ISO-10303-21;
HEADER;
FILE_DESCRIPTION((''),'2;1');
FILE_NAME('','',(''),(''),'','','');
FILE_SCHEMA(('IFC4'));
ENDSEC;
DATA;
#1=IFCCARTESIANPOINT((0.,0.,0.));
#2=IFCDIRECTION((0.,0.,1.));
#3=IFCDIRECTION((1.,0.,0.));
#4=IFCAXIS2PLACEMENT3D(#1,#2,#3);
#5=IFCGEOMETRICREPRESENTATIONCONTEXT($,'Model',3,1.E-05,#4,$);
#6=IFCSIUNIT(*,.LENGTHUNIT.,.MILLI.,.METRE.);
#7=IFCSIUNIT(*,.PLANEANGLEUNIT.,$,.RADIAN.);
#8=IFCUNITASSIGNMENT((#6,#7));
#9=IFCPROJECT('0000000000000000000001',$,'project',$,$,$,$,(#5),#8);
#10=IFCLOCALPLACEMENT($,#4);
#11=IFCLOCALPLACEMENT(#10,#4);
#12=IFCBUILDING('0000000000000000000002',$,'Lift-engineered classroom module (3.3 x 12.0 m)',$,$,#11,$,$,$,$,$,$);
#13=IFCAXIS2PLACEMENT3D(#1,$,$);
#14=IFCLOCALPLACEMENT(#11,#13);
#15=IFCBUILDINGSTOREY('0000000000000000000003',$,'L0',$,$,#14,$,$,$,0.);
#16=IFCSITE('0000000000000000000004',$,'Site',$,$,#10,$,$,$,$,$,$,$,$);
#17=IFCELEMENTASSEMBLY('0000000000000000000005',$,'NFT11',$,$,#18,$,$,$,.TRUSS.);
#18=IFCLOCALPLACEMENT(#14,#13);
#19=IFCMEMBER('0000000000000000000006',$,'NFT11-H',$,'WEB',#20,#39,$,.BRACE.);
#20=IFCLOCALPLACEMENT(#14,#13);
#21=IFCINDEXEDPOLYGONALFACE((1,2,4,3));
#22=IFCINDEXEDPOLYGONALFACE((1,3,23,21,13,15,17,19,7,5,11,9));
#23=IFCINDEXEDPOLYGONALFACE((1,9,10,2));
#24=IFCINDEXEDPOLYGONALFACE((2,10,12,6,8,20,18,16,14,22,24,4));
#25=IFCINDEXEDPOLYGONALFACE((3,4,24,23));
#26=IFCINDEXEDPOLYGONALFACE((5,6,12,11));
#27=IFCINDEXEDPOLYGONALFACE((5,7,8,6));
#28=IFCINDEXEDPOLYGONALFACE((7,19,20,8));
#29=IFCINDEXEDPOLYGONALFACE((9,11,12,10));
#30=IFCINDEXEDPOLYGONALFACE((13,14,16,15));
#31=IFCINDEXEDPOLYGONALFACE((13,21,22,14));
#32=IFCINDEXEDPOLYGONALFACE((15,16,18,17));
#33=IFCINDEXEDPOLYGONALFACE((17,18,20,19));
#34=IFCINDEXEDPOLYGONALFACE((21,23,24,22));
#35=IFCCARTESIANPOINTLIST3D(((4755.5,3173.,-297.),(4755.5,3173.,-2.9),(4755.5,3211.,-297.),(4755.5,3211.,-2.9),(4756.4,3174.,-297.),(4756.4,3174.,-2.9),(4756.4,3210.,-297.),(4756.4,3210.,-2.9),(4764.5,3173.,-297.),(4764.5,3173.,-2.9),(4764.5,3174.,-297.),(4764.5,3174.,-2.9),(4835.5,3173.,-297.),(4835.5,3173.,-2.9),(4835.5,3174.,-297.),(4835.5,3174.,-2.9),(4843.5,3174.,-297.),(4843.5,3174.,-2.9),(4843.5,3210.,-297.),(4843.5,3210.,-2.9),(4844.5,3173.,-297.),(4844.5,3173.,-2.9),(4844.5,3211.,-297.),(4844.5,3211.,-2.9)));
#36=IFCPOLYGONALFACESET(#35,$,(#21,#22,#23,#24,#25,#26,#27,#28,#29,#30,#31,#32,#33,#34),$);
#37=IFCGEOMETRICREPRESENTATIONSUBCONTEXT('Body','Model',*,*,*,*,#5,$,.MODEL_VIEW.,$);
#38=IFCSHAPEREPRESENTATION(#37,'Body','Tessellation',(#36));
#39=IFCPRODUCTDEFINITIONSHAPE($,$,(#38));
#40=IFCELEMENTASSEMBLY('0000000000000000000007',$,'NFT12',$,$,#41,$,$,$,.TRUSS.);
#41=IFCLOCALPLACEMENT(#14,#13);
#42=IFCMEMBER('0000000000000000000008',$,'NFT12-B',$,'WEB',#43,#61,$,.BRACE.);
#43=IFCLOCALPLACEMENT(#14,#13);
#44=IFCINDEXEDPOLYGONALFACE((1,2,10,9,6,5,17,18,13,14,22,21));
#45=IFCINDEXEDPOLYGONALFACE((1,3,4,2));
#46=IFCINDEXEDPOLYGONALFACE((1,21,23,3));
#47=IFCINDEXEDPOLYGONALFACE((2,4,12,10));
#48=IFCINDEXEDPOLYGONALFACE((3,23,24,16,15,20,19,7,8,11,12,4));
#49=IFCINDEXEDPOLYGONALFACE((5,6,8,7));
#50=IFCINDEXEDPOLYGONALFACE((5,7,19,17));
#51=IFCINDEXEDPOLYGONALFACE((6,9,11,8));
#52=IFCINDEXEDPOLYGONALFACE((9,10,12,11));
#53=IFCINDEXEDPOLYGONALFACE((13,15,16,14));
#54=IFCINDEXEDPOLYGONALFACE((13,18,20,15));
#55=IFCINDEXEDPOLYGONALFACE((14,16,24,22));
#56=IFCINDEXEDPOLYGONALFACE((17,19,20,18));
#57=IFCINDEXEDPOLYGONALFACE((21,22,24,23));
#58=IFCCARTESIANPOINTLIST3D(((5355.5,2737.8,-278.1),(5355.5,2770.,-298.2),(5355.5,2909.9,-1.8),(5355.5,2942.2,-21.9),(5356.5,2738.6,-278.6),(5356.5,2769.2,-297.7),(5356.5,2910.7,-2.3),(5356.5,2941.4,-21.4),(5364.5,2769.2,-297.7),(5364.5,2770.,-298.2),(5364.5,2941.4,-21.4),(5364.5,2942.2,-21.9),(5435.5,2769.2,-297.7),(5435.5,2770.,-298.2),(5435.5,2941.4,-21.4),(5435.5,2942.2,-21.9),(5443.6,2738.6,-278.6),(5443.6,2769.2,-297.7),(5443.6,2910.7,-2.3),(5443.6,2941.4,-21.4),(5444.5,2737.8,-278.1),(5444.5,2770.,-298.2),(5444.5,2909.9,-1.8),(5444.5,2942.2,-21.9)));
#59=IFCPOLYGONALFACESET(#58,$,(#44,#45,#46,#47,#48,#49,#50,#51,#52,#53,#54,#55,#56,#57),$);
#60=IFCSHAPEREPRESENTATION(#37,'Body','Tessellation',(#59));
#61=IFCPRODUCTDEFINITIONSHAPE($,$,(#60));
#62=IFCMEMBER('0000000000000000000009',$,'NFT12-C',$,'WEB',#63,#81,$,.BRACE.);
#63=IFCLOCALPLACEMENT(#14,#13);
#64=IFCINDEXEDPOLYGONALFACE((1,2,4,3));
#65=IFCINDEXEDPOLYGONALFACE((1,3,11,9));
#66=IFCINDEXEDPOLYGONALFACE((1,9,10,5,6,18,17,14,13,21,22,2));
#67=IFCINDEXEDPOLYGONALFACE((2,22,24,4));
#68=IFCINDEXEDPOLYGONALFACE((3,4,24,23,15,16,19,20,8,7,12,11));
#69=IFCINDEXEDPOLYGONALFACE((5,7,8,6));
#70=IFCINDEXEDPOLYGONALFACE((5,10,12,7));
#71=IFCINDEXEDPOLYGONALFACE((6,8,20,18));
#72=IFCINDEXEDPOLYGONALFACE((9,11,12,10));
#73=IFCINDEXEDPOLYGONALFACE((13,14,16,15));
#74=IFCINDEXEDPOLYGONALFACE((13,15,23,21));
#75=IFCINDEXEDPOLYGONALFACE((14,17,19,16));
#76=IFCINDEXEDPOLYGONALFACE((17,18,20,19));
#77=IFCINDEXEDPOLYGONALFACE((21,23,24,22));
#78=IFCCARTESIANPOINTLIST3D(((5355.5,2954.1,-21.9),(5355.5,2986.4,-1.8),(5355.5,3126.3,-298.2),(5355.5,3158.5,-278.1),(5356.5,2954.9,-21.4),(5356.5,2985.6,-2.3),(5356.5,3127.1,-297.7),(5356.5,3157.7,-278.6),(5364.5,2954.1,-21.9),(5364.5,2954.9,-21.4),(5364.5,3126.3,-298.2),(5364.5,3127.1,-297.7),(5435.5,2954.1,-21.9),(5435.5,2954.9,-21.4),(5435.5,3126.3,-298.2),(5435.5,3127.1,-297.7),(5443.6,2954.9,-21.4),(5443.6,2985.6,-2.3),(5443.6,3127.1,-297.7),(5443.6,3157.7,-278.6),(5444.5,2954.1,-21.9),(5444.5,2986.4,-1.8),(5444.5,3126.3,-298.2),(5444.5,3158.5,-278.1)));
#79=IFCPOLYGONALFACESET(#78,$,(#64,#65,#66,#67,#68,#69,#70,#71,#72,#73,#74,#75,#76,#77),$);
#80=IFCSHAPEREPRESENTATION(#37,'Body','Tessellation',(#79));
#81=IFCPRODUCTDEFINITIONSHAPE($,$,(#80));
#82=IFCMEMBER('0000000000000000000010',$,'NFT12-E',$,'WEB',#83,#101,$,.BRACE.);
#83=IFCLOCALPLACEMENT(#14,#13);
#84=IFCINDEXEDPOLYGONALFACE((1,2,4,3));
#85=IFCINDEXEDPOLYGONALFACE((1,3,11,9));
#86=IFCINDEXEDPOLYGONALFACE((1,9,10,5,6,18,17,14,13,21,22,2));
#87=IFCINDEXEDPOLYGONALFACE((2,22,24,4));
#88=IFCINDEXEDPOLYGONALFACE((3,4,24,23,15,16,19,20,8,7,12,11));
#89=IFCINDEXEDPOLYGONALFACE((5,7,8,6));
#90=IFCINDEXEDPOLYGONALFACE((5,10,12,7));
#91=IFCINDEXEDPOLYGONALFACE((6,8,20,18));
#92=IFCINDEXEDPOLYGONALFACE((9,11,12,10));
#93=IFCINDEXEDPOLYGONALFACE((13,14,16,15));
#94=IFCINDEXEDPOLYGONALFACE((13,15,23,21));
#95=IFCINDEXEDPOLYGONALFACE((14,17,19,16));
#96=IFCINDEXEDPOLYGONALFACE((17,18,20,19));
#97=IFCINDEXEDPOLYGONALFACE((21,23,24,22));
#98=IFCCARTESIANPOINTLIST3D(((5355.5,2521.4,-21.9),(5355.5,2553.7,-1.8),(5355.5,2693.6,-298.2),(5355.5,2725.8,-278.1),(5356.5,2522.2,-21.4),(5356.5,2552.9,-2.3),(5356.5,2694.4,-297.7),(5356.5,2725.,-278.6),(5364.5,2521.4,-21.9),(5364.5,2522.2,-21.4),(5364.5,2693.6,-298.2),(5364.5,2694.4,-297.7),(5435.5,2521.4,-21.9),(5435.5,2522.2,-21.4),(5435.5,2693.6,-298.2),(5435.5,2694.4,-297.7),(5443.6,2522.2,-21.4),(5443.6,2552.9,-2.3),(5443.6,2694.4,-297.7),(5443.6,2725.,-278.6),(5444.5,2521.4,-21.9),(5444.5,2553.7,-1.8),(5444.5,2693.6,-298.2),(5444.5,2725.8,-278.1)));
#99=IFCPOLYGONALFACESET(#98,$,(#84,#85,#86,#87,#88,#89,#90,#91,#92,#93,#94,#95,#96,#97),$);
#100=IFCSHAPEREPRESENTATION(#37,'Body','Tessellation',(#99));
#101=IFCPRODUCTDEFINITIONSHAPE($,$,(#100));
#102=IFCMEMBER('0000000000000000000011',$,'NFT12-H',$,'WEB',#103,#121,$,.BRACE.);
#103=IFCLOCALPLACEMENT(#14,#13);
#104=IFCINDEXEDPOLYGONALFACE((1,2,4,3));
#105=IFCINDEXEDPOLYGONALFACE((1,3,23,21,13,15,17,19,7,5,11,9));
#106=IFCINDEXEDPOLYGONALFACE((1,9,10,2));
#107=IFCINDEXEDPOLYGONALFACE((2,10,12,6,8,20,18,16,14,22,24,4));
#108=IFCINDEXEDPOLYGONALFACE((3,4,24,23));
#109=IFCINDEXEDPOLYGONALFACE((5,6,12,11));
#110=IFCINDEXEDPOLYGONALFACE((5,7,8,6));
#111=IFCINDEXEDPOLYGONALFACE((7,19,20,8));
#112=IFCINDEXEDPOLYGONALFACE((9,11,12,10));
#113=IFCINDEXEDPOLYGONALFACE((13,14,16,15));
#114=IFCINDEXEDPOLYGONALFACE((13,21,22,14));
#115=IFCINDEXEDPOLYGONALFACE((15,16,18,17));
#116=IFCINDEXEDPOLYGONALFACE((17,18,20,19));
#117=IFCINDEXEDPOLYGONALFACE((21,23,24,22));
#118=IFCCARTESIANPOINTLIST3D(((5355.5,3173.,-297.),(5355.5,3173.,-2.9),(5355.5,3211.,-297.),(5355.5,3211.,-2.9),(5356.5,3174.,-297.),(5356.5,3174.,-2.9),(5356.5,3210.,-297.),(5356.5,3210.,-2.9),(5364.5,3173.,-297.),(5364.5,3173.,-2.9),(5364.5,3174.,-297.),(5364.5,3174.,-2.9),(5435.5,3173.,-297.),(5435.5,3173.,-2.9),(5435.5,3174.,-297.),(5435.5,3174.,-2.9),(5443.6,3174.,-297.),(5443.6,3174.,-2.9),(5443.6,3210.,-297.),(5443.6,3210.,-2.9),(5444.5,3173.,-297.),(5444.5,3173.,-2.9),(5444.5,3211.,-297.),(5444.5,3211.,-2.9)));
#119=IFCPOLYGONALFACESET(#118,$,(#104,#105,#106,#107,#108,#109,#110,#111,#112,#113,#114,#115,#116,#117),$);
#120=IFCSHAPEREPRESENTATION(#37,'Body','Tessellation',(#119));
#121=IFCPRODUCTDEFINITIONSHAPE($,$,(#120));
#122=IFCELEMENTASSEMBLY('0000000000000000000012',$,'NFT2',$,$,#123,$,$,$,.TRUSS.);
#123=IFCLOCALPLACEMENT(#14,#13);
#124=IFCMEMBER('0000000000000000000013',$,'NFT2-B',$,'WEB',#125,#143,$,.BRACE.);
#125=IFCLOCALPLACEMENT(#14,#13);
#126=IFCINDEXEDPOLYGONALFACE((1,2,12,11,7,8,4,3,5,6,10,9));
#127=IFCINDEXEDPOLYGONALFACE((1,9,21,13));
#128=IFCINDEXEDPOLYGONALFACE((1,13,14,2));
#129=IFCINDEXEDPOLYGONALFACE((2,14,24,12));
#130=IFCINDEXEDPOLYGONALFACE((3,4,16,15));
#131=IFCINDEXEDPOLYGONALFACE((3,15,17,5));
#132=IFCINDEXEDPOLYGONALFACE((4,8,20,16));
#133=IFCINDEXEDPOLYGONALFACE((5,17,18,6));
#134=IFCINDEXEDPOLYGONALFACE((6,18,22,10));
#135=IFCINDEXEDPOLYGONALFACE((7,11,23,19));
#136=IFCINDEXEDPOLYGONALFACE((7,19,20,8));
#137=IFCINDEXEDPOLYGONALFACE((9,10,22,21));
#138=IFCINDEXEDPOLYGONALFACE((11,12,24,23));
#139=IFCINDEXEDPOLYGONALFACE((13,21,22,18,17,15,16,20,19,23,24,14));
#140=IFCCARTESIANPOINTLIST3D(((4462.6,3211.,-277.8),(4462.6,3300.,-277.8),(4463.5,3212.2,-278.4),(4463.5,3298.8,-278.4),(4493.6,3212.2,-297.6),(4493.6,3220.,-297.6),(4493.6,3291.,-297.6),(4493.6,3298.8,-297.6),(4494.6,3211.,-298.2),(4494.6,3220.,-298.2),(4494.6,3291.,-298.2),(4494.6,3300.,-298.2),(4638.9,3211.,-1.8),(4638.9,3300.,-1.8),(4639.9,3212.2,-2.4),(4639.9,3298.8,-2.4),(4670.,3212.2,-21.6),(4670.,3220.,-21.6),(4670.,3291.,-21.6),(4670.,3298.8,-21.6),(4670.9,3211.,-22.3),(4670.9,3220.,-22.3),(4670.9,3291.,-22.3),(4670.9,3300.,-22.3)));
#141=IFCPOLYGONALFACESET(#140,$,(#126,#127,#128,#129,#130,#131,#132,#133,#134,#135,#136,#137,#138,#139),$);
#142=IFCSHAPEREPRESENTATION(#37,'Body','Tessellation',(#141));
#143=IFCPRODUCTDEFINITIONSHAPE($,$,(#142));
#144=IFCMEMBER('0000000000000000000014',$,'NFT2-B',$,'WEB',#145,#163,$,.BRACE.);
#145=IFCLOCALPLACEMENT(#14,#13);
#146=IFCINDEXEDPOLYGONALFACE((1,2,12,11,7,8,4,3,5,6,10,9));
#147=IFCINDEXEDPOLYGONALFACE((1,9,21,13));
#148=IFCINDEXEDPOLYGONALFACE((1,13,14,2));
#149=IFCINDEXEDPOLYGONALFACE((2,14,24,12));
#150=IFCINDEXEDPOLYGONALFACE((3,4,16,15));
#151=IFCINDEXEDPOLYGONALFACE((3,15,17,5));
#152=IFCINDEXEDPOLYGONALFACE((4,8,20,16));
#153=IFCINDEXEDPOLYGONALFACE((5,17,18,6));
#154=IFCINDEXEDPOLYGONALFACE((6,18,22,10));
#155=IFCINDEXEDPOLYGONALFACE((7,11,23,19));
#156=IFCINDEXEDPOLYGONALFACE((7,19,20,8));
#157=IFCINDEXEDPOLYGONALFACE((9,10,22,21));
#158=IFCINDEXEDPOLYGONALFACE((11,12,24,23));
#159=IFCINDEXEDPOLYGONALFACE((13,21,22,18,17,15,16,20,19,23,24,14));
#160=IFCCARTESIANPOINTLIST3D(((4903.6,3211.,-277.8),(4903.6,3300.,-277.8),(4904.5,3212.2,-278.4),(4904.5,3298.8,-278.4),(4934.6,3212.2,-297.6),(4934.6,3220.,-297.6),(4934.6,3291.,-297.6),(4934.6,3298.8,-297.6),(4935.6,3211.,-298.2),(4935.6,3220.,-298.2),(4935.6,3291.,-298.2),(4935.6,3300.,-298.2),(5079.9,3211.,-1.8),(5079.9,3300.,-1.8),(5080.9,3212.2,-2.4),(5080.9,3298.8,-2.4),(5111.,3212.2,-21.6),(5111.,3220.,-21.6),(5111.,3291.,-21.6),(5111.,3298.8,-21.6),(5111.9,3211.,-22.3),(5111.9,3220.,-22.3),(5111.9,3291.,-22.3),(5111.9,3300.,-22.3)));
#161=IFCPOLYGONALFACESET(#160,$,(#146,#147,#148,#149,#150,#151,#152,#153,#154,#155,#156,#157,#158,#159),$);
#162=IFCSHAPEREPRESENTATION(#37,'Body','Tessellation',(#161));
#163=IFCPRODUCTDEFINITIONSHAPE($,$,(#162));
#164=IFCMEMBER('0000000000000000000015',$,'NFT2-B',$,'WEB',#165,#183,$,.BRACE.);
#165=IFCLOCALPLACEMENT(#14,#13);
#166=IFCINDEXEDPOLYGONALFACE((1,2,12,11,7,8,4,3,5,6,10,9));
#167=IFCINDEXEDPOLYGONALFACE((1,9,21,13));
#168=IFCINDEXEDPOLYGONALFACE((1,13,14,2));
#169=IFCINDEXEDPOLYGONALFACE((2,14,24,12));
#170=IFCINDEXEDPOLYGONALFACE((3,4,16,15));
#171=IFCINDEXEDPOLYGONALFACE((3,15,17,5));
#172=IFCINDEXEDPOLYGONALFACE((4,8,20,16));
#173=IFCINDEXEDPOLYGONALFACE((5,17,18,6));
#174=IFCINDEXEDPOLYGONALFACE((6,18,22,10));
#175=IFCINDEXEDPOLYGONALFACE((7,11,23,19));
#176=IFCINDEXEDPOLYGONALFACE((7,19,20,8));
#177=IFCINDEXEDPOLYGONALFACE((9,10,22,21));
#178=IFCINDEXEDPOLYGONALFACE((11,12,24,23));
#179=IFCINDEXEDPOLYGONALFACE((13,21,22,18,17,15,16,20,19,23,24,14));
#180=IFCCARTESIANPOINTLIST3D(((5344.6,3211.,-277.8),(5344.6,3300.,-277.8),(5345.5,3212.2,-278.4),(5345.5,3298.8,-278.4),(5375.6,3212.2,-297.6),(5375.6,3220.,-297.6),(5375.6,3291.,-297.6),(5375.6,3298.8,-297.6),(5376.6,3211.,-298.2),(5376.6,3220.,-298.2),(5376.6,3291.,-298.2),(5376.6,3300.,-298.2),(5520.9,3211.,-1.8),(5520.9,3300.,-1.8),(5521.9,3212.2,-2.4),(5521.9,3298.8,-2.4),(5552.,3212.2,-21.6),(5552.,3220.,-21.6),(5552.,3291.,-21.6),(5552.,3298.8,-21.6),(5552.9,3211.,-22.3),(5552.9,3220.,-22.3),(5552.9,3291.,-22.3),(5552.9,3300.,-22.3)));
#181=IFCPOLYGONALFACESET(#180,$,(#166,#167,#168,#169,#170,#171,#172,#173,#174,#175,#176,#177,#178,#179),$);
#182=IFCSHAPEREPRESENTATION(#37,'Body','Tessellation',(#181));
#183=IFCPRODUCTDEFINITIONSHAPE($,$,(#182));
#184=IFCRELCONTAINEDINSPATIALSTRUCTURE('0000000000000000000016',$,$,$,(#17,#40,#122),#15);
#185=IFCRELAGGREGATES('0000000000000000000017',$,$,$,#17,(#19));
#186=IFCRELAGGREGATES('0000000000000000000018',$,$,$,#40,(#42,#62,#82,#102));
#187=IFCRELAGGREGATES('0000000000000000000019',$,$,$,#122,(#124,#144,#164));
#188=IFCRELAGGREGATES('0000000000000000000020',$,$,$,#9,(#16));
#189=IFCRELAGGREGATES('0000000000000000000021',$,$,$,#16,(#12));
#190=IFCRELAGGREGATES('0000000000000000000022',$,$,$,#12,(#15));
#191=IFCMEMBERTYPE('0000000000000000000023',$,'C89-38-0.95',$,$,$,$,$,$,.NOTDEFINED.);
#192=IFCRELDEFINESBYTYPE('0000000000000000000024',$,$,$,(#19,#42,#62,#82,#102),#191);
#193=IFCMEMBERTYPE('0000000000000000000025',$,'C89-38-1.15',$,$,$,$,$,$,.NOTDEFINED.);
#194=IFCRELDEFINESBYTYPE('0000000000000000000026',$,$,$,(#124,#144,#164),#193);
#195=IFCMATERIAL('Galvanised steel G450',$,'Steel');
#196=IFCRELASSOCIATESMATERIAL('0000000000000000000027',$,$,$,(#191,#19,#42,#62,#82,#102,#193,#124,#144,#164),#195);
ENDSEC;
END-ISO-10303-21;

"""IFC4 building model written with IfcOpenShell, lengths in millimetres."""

from ifc_helpers import new_model, si_unit, frame, origin, origin_with_axes, origin_2d, place, context, subcontext, project, spatial, c_section, extrude, material, material_profile, profile_set, profile_usage, type_object, element, aggregate, save


model = new_model("IFC4")

# Units and contexts
model_context = context("Model", 3, precision=1e-05, world=origin_with_axes())
body_context = subcontext(model_context, "Body", "Model", "MODEL_VIEW")
ifc_project = project(units=[si_unit("LENGTHUNIT", "METRE", prefix="MILLI"), si_unit("PLANEANGLEUNIT", "RADIAN")], contexts=[model_context])

# Site, building, storey
site_placement = place(None, origin_with_axes())
site = spatial("IfcSite", under=ifc_project, at=site_placement, Name="Site")
building_placement = place(site_placement, origin_with_axes())
building = spatial("IfcBuilding", under=site, at=building_placement, Name="Lift-engineered classroom module (3.3 x 12.0 m)")
storey_placement = place(building_placement, origin())
storey = spatial("IfcBuildingStorey", under=building, at=storey_placement, Name="L0", Elevation=0.0)

# Element assemblies, members
ifc_material = material(Name="Galvanised steel G450", Category="Steel")
ifc_material_profile_1 = material_profile(ifc_material, c_section(Depth=89.0, Width=38.0, WallThickness=0.9, Girth=9.0, at=origin_2d()), Name="C89-38-0.95")
ifc_profile_set_1 = profile_set([ifc_material_profile_1], Name="C89-38-0.95")
ifc_profile_usage_1 = profile_usage(ifc_profile_set_1)
member_type_1 = type_object("IfcMemberType", Name="C89-38-0.95", PredefinedType="NOTDEFINED", material=ifc_profile_set_1)
assembly_1_placement = place(storey_placement, frame((4800.0, 89.0, -300.0)))
assembly_1 = element("IfcElementAssembly", 1, at=assembly_1_placement, inside=storey, Name="NFT11", PredefinedType="TRUSS")
member_1_placement = place(assembly_1_placement, frame((0.0, 3103.0, 2.9), z_axis=(0.0, 0.0, 1.0), x_axis=(0.0, -1.0, 0.0)))
member_1 = element("IfcMember", 2, at=member_1_placement, type_object=member_type_1, material=ifc_profile_usage_1, Name="NFT11-H", ObjectType="WEB", PredefinedType="BRACE", context=body_context, shape_type="SweptSolid", body=[
    extrude(c_section(Depth=89.0, Width=38.0, WallThickness=0.9, Girth=9.0, at=origin_2d()), origin(), (0.0, 0.0, 1.0), 294.1),
])
aggregate(assembly_1, [member_1])
assembly_2_placement = place(storey_placement, frame((5400.0, 89.0, -300.0)))
assembly_2 = element("IfcElementAssembly", 3, at=assembly_2_placement, inside=storey, Name="NFT12", PredefinedType="TRUSS")
member_2_placement = place(assembly_2_placement, frame((0.0, 2664.9, 11.8), z_axis=(0.0, 0.528797, 0.848748), x_axis=(0.0, 0.848748, -0.528797)))
member_2 = element("IfcMember", 4, at=member_2_placement, type_object=member_type_1, material=ifc_profile_usage_1, Name="NFT12-B", ObjectType="WEB", PredefinedType="BRACE", context=body_context, shape_type="SweptSolid", body=[
    extrude(c_section(Depth=89.0, Width=38.0, WallThickness=0.9, Girth=9.0, at=origin_2d()), origin(), (0.0, 0.0, 1.0), 325.6),
])
member_3_placement = place(assembly_2_placement, frame((0.0, 3053.4, 11.8), z_axis=(0.0, -0.528797, 0.848748), x_axis=(0.0, -0.848748, -0.528797)))
member_3 = element("IfcMember", 5, at=member_3_placement, type_object=member_type_1, material=ifc_profile_usage_1, Name="NFT12-C", ObjectType="WEB", PredefinedType="BRACE", context=body_context, shape_type="SweptSolid", body=[
    extrude(c_section(Depth=89.0, Width=38.0, WallThickness=0.9, Girth=9.0, at=origin_2d()), origin(), (0.0, 0.0, 1.0), 325.6),
])
member_4_placement = place(assembly_2_placement, frame((0.0, 2620.7, 11.8), z_axis=(0.0, -0.528775, 0.848762), x_axis=(0.0, -0.848762, -0.528775)))
member_4 = element("IfcMember", 6, at=member_4_placement, type_object=member_type_1, material=ifc_profile_usage_1, Name="NFT12-E", ObjectType="WEB", PredefinedType="BRACE", context=body_context, shape_type="SweptSolid", body=[
    extrude(c_section(Depth=89.0, Width=38.0, WallThickness=0.9, Girth=9.0, at=origin_2d()), origin(), (0.0, 0.0, 1.0), 325.6),
])
member_5_placement = place(assembly_2_placement, frame((0.0, 3103.0, 2.9), z_axis=(0.0, 0.0, 1.0), x_axis=(0.0, -1.0, 0.0)))
member_5 = element("IfcMember", 7, at=member_5_placement, type_object=member_type_1, material=ifc_profile_usage_1, Name="NFT12-H", ObjectType="WEB", PredefinedType="BRACE", context=body_context, shape_type="SweptSolid", body=[
    extrude(c_section(Depth=89.0, Width=38.0, WallThickness=0.9, Girth=9.0, at=origin_2d()), origin(), (0.0, 0.0, 1.0), 294.1),
])
aggregate(assembly_2, [member_2, member_3, member_4, member_5])
assembly_3_placement = place(storey_placement, frame((0.0, 3255.5, -300.0)))
assembly_3 = element("IfcElementAssembly", 8, at=assembly_3_placement, inside=storey, Name="NFT2", PredefinedType="TRUSS")
ifc_material_profile_2 = material_profile(ifc_material, c_section(Depth=89.0, Width=38.0, WallThickness=1.1, Girth=9.0, at=origin_2d()), Name="C89-38-1.15")
ifc_profile_set_2 = profile_set([ifc_material_profile_2], Name="C89-38-1.15")
ifc_profile_usage_2 = profile_usage(ifc_profile_set_2)
member_type_2 = type_object("IfcMemberType", Name="C89-38-1.15", PredefinedType="NOTDEFINED", material=ifc_profile_set_2)
member_6_placement = place(assembly_3_placement, frame((4478.6, 0.0, 12.0), z_axis=(0.538459, 0.0, 0.842652), x_axis=(0.842652, 0.0, -0.538459)))
member_6 = element("IfcMember", 9, at=member_6_placement, type_object=member_type_2, material=ifc_profile_usage_2, Name="NFT2-B", ObjectType="WEB", PredefinedType="BRACE", context=body_context, shape_type="SweptSolid", body=[
    extrude(c_section(Depth=89.0, Width=38.0, WallThickness=1.1, Girth=9.0, at=origin_2d()), origin(), (0.0, 0.0, 1.0), 327.5),
])
member_7_placement = place(assembly_3_placement, frame((4919.6, 0.0, 12.0), z_axis=(0.538459, 0.0, 0.842652), x_axis=(0.842652, 0.0, -0.538459)))
member_7 = element("IfcMember", 10, at=member_7_placement, type_object=member_type_2, material=ifc_profile_usage_2, Name="NFT2-B", ObjectType="WEB", PredefinedType="BRACE", context=body_context, shape_type="SweptSolid", body=[
    extrude(c_section(Depth=89.0, Width=38.0, WallThickness=1.1, Girth=9.0, at=origin_2d()), origin(), (0.0, 0.0, 1.0), 327.5),
])
member_8_placement = place(assembly_3_placement, frame((5360.6, 0.0, 12.0), z_axis=(0.538459, 0.0, 0.842652), x_axis=(0.842652, 0.0, -0.538459)))
member_8 = element("IfcMember", 11, at=member_8_placement, type_object=member_type_2, material=ifc_profile_usage_2, Name="NFT2-B", ObjectType="WEB", PredefinedType="BRACE", context=body_context, shape_type="SweptSolid", body=[
    extrude(c_section(Depth=89.0, Width=38.0, WallThickness=1.1, Girth=9.0, at=origin_2d()), origin(), (0.0, 0.0, 1.0), 327.5),
])
aggregate(assembly_3, [member_6, member_7, member_8])

save(model, "model.ifc")
